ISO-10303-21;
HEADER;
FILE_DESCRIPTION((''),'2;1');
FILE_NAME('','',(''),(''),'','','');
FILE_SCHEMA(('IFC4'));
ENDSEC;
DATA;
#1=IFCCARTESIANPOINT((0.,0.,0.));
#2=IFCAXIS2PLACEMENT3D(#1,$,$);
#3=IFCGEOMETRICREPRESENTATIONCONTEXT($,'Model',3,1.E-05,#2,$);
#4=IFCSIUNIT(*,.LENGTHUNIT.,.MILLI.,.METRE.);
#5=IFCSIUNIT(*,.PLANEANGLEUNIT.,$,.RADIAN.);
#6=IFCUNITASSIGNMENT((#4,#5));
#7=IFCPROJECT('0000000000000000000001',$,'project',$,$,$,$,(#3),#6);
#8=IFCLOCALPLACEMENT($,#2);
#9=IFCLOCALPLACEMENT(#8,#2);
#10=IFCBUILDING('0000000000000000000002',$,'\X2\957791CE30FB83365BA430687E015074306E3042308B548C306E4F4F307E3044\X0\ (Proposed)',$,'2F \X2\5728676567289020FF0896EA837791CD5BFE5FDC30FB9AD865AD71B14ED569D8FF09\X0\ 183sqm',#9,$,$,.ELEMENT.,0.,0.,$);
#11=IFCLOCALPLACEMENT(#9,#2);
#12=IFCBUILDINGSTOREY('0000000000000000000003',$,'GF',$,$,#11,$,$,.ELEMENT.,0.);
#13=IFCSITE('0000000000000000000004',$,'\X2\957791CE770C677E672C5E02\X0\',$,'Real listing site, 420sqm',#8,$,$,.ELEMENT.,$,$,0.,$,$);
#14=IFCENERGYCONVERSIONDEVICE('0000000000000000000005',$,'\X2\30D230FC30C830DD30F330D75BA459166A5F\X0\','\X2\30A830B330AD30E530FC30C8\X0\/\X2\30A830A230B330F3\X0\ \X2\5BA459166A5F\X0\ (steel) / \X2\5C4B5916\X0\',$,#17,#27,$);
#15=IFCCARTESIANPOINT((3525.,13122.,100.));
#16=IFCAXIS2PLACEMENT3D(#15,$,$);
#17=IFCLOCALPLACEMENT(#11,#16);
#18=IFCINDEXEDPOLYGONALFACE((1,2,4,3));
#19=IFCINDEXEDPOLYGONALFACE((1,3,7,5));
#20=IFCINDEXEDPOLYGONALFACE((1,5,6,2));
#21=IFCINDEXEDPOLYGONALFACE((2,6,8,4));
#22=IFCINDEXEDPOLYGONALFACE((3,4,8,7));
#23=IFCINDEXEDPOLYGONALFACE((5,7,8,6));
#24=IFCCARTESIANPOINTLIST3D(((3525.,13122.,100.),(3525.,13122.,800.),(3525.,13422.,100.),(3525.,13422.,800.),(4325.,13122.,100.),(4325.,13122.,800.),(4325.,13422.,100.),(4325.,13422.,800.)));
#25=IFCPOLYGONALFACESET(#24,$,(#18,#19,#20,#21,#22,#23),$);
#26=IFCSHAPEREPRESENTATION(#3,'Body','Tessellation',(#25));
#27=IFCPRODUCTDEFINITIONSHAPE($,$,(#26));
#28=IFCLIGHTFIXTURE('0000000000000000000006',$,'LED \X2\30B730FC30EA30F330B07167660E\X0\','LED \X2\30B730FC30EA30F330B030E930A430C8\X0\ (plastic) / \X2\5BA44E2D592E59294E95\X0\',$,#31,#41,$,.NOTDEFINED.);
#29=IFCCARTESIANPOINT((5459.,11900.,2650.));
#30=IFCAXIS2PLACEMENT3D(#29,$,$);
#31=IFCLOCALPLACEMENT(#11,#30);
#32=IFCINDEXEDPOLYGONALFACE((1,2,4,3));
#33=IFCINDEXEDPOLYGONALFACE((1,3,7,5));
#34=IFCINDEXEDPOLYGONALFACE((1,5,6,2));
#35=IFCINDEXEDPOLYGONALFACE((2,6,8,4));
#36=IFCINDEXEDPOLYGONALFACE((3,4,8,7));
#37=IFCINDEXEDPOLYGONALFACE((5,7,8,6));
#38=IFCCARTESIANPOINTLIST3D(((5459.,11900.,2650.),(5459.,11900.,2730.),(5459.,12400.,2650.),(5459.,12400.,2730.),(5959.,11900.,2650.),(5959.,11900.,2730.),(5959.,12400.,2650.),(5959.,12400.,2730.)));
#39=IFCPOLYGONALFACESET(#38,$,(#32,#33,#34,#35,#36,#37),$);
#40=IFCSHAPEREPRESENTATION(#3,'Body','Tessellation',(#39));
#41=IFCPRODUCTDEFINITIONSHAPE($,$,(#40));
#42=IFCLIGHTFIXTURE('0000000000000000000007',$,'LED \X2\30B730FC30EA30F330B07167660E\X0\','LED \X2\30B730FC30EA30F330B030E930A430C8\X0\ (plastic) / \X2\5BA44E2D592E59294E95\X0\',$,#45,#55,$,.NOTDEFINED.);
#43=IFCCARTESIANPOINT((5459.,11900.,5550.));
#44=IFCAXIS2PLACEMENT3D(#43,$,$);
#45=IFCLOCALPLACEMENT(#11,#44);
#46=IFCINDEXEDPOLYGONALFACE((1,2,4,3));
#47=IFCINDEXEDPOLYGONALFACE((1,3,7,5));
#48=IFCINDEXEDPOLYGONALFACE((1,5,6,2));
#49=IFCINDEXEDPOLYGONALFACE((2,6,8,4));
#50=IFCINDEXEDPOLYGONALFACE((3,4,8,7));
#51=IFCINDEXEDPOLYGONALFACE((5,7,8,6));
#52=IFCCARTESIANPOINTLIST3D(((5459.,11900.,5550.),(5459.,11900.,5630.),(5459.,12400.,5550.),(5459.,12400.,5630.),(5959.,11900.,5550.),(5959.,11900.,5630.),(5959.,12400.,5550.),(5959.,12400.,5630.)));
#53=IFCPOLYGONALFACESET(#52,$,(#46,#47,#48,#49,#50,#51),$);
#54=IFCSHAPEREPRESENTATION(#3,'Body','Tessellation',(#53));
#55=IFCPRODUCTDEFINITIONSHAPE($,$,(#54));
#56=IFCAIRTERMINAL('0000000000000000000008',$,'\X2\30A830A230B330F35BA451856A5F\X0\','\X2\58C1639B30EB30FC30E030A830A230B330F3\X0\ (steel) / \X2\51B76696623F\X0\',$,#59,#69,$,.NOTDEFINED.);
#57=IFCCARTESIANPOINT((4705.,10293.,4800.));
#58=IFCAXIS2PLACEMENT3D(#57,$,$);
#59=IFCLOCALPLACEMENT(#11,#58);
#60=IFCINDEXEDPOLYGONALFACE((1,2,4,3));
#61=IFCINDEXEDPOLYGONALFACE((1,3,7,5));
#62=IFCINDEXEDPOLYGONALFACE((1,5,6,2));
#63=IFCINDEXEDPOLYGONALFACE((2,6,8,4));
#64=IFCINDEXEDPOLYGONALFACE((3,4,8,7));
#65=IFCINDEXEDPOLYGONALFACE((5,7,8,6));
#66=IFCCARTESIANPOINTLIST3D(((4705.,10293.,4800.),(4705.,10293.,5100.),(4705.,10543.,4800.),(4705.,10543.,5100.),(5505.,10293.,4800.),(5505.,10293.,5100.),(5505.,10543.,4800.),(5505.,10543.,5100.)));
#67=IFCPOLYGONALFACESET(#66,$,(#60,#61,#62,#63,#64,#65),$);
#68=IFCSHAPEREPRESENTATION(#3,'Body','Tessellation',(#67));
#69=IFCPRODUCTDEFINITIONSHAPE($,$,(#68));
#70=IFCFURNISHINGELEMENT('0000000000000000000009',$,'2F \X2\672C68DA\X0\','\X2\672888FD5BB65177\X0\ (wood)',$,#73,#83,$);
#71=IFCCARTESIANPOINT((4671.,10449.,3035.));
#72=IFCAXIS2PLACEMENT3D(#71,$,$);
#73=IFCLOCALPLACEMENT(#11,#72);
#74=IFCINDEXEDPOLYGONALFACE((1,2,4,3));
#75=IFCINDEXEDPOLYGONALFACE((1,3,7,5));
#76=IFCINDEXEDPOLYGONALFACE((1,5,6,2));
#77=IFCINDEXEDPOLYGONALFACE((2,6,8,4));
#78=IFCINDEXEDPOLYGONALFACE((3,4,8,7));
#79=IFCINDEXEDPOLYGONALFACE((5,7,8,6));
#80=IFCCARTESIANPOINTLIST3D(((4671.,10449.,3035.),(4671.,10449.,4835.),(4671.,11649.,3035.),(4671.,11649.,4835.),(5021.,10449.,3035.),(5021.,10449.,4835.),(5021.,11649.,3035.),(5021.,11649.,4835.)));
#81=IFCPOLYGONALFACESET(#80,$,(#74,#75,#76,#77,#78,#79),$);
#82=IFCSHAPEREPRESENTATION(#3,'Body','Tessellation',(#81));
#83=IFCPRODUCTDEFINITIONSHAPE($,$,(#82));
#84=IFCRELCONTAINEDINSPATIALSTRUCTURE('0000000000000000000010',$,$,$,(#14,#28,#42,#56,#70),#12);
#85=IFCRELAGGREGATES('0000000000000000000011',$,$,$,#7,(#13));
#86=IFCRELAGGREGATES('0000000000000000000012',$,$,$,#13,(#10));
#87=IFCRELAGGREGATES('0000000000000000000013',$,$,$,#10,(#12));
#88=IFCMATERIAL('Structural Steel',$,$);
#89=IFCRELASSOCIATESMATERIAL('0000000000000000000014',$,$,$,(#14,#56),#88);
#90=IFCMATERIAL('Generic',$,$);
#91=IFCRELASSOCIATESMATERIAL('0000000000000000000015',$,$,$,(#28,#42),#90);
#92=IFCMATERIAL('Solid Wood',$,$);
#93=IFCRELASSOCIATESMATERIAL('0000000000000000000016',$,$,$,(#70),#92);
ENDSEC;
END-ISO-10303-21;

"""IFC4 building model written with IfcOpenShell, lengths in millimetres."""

from ifc_helpers import new_model, si_unit, frame, frame_2d, origin, place, context, project, spatial, rectangle, extrude, material, element, save


model = new_model("IFC4")

# Units and contexts
model_context = context("Model", 3, precision=1e-05, world=origin())
ifc_project = project(units=[si_unit("LENGTHUNIT", "METRE", prefix="MILLI"), si_unit("PLANEANGLEUNIT", "RADIAN")], contexts=[model_context])

# Site, building, storey
site_placement = place(None, origin())
site = spatial("IfcSite", under=ifc_project, at=site_placement, Name="長野県松本市", ObjectType="Real listing site, 420sqm", CompositionType="ELEMENT", RefElevation=0.0)
building_placement = place(site_placement, origin())
building = spatial("IfcBuilding", under=site, at=building_placement, Name="長野・茶室と縁側のある和の住まい (Proposed)", ObjectType="2F 在来木造（雪荷重対応・高断熱仕様） 183sqm", CompositionType="ELEMENT", ElevationOfRefHeight=0.0, ElevationOfTerrain=0.0)
storey_placement = place(building_placement, origin())
storey = spatial("IfcBuildingStorey", under=building, at=storey_placement, Name="GF", CompositionType="ELEMENT", Elevation=0.0)

# Shared definitions
ifc_material_1 = material(Name="Solid Wood")

# Shared definitions
ifc_material_2 = material(Name="Structural Steel")

# Shared definitions
ifc_material_3 = material(Name="Generic")

# Energy conversion device
energy_conversion_device_placement = place(storey_placement, frame((3525.0, 13122.0, 100.0)))
element("IfcEnergyConversionDevice", 1, at=energy_conversion_device_placement, inside=storey, material=ifc_material_2, Name="ヒートポンプ室外機", Description="エコキュート/エアコン 室外機 (steel) / 屋外", context=model_context, shape_type="SweptSolid", body=[
    extrude(rectangle(XDim=800.0, YDim=300.0, at=frame_2d((400.0, 150.0))), frame((3525.0, 13122.0, 100.0)), (0.0, 0.0, 1.0), 700.0),
])

# Light fixtures
light_fixture_1_placement = place(storey_placement, frame((5459.0, 11900.0, 2650.0)))
element("IfcLightFixture", 2, at=light_fixture_1_placement, inside=storey, material=ifc_material_3, Name="LED シーリング照明", Description="LED シーリングライト (plastic) / 室中央天井", PredefinedType="NOTDEFINED", context=model_context, shape_type="SweptSolid", body=[
    extrude(rectangle(XDim=500.0, YDim=500.0, at=frame_2d((250.0, 250.0))), frame((5459.0, 11900.0, 2650.0)), (0.0, 0.0, 1.0), 80.0),
])
light_fixture_2_placement = place(storey_placement, frame((5459.0, 11900.0, 5550.0)))
element("IfcLightFixture", 3, at=light_fixture_2_placement, inside=storey, material=ifc_material_3, Name="LED シーリング照明", Description="LED シーリングライト (plastic) / 室中央天井", PredefinedType="NOTDEFINED", context=model_context, shape_type="SweptSolid", body=[
    extrude(rectangle(XDim=500.0, YDim=500.0, at=frame_2d((250.0, 250.0))), frame((5459.0, 11900.0, 5550.0)), (0.0, 0.0, 1.0), 80.0),
])

# Air terminal
air_terminal_placement = place(storey_placement, frame((4705.0, 10293.0, 4800.0)))
element("IfcAirTerminal", 4, at=air_terminal_placement, inside=storey, material=ifc_material_2, Name="エアコン室内機", Description="壁掛ルームエアコン (steel) / 冷暖房", PredefinedType="NOTDEFINED", context=model_context, shape_type="SweptSolid", body=[
    extrude(rectangle(XDim=800.0, YDim=250.0, at=frame_2d((400.0, 125.0))), frame((4705.0, 10293.0, 4800.0)), (0.0, 0.0, 1.0), 300.0),
])

# Furnishing element
furnishing_placement = place(storey_placement, frame((4671.0, 10449.0, 3035.0)))
element("IfcFurnishingElement", 5, at=furnishing_placement, inside=storey, material=ifc_material_1, Name="2F 本棚", Description="木製家具 (wood)", context=model_context, shape_type="SweptSolid", body=[
    extrude(rectangle(XDim=350.0, YDim=1200.0, at=frame_2d((175.0, 600.0))), frame((4671.0, 10449.0, 3035.0)), (0.0, 0.0, 1.0), 1800.0),
])

save(model, "model.ifc")
